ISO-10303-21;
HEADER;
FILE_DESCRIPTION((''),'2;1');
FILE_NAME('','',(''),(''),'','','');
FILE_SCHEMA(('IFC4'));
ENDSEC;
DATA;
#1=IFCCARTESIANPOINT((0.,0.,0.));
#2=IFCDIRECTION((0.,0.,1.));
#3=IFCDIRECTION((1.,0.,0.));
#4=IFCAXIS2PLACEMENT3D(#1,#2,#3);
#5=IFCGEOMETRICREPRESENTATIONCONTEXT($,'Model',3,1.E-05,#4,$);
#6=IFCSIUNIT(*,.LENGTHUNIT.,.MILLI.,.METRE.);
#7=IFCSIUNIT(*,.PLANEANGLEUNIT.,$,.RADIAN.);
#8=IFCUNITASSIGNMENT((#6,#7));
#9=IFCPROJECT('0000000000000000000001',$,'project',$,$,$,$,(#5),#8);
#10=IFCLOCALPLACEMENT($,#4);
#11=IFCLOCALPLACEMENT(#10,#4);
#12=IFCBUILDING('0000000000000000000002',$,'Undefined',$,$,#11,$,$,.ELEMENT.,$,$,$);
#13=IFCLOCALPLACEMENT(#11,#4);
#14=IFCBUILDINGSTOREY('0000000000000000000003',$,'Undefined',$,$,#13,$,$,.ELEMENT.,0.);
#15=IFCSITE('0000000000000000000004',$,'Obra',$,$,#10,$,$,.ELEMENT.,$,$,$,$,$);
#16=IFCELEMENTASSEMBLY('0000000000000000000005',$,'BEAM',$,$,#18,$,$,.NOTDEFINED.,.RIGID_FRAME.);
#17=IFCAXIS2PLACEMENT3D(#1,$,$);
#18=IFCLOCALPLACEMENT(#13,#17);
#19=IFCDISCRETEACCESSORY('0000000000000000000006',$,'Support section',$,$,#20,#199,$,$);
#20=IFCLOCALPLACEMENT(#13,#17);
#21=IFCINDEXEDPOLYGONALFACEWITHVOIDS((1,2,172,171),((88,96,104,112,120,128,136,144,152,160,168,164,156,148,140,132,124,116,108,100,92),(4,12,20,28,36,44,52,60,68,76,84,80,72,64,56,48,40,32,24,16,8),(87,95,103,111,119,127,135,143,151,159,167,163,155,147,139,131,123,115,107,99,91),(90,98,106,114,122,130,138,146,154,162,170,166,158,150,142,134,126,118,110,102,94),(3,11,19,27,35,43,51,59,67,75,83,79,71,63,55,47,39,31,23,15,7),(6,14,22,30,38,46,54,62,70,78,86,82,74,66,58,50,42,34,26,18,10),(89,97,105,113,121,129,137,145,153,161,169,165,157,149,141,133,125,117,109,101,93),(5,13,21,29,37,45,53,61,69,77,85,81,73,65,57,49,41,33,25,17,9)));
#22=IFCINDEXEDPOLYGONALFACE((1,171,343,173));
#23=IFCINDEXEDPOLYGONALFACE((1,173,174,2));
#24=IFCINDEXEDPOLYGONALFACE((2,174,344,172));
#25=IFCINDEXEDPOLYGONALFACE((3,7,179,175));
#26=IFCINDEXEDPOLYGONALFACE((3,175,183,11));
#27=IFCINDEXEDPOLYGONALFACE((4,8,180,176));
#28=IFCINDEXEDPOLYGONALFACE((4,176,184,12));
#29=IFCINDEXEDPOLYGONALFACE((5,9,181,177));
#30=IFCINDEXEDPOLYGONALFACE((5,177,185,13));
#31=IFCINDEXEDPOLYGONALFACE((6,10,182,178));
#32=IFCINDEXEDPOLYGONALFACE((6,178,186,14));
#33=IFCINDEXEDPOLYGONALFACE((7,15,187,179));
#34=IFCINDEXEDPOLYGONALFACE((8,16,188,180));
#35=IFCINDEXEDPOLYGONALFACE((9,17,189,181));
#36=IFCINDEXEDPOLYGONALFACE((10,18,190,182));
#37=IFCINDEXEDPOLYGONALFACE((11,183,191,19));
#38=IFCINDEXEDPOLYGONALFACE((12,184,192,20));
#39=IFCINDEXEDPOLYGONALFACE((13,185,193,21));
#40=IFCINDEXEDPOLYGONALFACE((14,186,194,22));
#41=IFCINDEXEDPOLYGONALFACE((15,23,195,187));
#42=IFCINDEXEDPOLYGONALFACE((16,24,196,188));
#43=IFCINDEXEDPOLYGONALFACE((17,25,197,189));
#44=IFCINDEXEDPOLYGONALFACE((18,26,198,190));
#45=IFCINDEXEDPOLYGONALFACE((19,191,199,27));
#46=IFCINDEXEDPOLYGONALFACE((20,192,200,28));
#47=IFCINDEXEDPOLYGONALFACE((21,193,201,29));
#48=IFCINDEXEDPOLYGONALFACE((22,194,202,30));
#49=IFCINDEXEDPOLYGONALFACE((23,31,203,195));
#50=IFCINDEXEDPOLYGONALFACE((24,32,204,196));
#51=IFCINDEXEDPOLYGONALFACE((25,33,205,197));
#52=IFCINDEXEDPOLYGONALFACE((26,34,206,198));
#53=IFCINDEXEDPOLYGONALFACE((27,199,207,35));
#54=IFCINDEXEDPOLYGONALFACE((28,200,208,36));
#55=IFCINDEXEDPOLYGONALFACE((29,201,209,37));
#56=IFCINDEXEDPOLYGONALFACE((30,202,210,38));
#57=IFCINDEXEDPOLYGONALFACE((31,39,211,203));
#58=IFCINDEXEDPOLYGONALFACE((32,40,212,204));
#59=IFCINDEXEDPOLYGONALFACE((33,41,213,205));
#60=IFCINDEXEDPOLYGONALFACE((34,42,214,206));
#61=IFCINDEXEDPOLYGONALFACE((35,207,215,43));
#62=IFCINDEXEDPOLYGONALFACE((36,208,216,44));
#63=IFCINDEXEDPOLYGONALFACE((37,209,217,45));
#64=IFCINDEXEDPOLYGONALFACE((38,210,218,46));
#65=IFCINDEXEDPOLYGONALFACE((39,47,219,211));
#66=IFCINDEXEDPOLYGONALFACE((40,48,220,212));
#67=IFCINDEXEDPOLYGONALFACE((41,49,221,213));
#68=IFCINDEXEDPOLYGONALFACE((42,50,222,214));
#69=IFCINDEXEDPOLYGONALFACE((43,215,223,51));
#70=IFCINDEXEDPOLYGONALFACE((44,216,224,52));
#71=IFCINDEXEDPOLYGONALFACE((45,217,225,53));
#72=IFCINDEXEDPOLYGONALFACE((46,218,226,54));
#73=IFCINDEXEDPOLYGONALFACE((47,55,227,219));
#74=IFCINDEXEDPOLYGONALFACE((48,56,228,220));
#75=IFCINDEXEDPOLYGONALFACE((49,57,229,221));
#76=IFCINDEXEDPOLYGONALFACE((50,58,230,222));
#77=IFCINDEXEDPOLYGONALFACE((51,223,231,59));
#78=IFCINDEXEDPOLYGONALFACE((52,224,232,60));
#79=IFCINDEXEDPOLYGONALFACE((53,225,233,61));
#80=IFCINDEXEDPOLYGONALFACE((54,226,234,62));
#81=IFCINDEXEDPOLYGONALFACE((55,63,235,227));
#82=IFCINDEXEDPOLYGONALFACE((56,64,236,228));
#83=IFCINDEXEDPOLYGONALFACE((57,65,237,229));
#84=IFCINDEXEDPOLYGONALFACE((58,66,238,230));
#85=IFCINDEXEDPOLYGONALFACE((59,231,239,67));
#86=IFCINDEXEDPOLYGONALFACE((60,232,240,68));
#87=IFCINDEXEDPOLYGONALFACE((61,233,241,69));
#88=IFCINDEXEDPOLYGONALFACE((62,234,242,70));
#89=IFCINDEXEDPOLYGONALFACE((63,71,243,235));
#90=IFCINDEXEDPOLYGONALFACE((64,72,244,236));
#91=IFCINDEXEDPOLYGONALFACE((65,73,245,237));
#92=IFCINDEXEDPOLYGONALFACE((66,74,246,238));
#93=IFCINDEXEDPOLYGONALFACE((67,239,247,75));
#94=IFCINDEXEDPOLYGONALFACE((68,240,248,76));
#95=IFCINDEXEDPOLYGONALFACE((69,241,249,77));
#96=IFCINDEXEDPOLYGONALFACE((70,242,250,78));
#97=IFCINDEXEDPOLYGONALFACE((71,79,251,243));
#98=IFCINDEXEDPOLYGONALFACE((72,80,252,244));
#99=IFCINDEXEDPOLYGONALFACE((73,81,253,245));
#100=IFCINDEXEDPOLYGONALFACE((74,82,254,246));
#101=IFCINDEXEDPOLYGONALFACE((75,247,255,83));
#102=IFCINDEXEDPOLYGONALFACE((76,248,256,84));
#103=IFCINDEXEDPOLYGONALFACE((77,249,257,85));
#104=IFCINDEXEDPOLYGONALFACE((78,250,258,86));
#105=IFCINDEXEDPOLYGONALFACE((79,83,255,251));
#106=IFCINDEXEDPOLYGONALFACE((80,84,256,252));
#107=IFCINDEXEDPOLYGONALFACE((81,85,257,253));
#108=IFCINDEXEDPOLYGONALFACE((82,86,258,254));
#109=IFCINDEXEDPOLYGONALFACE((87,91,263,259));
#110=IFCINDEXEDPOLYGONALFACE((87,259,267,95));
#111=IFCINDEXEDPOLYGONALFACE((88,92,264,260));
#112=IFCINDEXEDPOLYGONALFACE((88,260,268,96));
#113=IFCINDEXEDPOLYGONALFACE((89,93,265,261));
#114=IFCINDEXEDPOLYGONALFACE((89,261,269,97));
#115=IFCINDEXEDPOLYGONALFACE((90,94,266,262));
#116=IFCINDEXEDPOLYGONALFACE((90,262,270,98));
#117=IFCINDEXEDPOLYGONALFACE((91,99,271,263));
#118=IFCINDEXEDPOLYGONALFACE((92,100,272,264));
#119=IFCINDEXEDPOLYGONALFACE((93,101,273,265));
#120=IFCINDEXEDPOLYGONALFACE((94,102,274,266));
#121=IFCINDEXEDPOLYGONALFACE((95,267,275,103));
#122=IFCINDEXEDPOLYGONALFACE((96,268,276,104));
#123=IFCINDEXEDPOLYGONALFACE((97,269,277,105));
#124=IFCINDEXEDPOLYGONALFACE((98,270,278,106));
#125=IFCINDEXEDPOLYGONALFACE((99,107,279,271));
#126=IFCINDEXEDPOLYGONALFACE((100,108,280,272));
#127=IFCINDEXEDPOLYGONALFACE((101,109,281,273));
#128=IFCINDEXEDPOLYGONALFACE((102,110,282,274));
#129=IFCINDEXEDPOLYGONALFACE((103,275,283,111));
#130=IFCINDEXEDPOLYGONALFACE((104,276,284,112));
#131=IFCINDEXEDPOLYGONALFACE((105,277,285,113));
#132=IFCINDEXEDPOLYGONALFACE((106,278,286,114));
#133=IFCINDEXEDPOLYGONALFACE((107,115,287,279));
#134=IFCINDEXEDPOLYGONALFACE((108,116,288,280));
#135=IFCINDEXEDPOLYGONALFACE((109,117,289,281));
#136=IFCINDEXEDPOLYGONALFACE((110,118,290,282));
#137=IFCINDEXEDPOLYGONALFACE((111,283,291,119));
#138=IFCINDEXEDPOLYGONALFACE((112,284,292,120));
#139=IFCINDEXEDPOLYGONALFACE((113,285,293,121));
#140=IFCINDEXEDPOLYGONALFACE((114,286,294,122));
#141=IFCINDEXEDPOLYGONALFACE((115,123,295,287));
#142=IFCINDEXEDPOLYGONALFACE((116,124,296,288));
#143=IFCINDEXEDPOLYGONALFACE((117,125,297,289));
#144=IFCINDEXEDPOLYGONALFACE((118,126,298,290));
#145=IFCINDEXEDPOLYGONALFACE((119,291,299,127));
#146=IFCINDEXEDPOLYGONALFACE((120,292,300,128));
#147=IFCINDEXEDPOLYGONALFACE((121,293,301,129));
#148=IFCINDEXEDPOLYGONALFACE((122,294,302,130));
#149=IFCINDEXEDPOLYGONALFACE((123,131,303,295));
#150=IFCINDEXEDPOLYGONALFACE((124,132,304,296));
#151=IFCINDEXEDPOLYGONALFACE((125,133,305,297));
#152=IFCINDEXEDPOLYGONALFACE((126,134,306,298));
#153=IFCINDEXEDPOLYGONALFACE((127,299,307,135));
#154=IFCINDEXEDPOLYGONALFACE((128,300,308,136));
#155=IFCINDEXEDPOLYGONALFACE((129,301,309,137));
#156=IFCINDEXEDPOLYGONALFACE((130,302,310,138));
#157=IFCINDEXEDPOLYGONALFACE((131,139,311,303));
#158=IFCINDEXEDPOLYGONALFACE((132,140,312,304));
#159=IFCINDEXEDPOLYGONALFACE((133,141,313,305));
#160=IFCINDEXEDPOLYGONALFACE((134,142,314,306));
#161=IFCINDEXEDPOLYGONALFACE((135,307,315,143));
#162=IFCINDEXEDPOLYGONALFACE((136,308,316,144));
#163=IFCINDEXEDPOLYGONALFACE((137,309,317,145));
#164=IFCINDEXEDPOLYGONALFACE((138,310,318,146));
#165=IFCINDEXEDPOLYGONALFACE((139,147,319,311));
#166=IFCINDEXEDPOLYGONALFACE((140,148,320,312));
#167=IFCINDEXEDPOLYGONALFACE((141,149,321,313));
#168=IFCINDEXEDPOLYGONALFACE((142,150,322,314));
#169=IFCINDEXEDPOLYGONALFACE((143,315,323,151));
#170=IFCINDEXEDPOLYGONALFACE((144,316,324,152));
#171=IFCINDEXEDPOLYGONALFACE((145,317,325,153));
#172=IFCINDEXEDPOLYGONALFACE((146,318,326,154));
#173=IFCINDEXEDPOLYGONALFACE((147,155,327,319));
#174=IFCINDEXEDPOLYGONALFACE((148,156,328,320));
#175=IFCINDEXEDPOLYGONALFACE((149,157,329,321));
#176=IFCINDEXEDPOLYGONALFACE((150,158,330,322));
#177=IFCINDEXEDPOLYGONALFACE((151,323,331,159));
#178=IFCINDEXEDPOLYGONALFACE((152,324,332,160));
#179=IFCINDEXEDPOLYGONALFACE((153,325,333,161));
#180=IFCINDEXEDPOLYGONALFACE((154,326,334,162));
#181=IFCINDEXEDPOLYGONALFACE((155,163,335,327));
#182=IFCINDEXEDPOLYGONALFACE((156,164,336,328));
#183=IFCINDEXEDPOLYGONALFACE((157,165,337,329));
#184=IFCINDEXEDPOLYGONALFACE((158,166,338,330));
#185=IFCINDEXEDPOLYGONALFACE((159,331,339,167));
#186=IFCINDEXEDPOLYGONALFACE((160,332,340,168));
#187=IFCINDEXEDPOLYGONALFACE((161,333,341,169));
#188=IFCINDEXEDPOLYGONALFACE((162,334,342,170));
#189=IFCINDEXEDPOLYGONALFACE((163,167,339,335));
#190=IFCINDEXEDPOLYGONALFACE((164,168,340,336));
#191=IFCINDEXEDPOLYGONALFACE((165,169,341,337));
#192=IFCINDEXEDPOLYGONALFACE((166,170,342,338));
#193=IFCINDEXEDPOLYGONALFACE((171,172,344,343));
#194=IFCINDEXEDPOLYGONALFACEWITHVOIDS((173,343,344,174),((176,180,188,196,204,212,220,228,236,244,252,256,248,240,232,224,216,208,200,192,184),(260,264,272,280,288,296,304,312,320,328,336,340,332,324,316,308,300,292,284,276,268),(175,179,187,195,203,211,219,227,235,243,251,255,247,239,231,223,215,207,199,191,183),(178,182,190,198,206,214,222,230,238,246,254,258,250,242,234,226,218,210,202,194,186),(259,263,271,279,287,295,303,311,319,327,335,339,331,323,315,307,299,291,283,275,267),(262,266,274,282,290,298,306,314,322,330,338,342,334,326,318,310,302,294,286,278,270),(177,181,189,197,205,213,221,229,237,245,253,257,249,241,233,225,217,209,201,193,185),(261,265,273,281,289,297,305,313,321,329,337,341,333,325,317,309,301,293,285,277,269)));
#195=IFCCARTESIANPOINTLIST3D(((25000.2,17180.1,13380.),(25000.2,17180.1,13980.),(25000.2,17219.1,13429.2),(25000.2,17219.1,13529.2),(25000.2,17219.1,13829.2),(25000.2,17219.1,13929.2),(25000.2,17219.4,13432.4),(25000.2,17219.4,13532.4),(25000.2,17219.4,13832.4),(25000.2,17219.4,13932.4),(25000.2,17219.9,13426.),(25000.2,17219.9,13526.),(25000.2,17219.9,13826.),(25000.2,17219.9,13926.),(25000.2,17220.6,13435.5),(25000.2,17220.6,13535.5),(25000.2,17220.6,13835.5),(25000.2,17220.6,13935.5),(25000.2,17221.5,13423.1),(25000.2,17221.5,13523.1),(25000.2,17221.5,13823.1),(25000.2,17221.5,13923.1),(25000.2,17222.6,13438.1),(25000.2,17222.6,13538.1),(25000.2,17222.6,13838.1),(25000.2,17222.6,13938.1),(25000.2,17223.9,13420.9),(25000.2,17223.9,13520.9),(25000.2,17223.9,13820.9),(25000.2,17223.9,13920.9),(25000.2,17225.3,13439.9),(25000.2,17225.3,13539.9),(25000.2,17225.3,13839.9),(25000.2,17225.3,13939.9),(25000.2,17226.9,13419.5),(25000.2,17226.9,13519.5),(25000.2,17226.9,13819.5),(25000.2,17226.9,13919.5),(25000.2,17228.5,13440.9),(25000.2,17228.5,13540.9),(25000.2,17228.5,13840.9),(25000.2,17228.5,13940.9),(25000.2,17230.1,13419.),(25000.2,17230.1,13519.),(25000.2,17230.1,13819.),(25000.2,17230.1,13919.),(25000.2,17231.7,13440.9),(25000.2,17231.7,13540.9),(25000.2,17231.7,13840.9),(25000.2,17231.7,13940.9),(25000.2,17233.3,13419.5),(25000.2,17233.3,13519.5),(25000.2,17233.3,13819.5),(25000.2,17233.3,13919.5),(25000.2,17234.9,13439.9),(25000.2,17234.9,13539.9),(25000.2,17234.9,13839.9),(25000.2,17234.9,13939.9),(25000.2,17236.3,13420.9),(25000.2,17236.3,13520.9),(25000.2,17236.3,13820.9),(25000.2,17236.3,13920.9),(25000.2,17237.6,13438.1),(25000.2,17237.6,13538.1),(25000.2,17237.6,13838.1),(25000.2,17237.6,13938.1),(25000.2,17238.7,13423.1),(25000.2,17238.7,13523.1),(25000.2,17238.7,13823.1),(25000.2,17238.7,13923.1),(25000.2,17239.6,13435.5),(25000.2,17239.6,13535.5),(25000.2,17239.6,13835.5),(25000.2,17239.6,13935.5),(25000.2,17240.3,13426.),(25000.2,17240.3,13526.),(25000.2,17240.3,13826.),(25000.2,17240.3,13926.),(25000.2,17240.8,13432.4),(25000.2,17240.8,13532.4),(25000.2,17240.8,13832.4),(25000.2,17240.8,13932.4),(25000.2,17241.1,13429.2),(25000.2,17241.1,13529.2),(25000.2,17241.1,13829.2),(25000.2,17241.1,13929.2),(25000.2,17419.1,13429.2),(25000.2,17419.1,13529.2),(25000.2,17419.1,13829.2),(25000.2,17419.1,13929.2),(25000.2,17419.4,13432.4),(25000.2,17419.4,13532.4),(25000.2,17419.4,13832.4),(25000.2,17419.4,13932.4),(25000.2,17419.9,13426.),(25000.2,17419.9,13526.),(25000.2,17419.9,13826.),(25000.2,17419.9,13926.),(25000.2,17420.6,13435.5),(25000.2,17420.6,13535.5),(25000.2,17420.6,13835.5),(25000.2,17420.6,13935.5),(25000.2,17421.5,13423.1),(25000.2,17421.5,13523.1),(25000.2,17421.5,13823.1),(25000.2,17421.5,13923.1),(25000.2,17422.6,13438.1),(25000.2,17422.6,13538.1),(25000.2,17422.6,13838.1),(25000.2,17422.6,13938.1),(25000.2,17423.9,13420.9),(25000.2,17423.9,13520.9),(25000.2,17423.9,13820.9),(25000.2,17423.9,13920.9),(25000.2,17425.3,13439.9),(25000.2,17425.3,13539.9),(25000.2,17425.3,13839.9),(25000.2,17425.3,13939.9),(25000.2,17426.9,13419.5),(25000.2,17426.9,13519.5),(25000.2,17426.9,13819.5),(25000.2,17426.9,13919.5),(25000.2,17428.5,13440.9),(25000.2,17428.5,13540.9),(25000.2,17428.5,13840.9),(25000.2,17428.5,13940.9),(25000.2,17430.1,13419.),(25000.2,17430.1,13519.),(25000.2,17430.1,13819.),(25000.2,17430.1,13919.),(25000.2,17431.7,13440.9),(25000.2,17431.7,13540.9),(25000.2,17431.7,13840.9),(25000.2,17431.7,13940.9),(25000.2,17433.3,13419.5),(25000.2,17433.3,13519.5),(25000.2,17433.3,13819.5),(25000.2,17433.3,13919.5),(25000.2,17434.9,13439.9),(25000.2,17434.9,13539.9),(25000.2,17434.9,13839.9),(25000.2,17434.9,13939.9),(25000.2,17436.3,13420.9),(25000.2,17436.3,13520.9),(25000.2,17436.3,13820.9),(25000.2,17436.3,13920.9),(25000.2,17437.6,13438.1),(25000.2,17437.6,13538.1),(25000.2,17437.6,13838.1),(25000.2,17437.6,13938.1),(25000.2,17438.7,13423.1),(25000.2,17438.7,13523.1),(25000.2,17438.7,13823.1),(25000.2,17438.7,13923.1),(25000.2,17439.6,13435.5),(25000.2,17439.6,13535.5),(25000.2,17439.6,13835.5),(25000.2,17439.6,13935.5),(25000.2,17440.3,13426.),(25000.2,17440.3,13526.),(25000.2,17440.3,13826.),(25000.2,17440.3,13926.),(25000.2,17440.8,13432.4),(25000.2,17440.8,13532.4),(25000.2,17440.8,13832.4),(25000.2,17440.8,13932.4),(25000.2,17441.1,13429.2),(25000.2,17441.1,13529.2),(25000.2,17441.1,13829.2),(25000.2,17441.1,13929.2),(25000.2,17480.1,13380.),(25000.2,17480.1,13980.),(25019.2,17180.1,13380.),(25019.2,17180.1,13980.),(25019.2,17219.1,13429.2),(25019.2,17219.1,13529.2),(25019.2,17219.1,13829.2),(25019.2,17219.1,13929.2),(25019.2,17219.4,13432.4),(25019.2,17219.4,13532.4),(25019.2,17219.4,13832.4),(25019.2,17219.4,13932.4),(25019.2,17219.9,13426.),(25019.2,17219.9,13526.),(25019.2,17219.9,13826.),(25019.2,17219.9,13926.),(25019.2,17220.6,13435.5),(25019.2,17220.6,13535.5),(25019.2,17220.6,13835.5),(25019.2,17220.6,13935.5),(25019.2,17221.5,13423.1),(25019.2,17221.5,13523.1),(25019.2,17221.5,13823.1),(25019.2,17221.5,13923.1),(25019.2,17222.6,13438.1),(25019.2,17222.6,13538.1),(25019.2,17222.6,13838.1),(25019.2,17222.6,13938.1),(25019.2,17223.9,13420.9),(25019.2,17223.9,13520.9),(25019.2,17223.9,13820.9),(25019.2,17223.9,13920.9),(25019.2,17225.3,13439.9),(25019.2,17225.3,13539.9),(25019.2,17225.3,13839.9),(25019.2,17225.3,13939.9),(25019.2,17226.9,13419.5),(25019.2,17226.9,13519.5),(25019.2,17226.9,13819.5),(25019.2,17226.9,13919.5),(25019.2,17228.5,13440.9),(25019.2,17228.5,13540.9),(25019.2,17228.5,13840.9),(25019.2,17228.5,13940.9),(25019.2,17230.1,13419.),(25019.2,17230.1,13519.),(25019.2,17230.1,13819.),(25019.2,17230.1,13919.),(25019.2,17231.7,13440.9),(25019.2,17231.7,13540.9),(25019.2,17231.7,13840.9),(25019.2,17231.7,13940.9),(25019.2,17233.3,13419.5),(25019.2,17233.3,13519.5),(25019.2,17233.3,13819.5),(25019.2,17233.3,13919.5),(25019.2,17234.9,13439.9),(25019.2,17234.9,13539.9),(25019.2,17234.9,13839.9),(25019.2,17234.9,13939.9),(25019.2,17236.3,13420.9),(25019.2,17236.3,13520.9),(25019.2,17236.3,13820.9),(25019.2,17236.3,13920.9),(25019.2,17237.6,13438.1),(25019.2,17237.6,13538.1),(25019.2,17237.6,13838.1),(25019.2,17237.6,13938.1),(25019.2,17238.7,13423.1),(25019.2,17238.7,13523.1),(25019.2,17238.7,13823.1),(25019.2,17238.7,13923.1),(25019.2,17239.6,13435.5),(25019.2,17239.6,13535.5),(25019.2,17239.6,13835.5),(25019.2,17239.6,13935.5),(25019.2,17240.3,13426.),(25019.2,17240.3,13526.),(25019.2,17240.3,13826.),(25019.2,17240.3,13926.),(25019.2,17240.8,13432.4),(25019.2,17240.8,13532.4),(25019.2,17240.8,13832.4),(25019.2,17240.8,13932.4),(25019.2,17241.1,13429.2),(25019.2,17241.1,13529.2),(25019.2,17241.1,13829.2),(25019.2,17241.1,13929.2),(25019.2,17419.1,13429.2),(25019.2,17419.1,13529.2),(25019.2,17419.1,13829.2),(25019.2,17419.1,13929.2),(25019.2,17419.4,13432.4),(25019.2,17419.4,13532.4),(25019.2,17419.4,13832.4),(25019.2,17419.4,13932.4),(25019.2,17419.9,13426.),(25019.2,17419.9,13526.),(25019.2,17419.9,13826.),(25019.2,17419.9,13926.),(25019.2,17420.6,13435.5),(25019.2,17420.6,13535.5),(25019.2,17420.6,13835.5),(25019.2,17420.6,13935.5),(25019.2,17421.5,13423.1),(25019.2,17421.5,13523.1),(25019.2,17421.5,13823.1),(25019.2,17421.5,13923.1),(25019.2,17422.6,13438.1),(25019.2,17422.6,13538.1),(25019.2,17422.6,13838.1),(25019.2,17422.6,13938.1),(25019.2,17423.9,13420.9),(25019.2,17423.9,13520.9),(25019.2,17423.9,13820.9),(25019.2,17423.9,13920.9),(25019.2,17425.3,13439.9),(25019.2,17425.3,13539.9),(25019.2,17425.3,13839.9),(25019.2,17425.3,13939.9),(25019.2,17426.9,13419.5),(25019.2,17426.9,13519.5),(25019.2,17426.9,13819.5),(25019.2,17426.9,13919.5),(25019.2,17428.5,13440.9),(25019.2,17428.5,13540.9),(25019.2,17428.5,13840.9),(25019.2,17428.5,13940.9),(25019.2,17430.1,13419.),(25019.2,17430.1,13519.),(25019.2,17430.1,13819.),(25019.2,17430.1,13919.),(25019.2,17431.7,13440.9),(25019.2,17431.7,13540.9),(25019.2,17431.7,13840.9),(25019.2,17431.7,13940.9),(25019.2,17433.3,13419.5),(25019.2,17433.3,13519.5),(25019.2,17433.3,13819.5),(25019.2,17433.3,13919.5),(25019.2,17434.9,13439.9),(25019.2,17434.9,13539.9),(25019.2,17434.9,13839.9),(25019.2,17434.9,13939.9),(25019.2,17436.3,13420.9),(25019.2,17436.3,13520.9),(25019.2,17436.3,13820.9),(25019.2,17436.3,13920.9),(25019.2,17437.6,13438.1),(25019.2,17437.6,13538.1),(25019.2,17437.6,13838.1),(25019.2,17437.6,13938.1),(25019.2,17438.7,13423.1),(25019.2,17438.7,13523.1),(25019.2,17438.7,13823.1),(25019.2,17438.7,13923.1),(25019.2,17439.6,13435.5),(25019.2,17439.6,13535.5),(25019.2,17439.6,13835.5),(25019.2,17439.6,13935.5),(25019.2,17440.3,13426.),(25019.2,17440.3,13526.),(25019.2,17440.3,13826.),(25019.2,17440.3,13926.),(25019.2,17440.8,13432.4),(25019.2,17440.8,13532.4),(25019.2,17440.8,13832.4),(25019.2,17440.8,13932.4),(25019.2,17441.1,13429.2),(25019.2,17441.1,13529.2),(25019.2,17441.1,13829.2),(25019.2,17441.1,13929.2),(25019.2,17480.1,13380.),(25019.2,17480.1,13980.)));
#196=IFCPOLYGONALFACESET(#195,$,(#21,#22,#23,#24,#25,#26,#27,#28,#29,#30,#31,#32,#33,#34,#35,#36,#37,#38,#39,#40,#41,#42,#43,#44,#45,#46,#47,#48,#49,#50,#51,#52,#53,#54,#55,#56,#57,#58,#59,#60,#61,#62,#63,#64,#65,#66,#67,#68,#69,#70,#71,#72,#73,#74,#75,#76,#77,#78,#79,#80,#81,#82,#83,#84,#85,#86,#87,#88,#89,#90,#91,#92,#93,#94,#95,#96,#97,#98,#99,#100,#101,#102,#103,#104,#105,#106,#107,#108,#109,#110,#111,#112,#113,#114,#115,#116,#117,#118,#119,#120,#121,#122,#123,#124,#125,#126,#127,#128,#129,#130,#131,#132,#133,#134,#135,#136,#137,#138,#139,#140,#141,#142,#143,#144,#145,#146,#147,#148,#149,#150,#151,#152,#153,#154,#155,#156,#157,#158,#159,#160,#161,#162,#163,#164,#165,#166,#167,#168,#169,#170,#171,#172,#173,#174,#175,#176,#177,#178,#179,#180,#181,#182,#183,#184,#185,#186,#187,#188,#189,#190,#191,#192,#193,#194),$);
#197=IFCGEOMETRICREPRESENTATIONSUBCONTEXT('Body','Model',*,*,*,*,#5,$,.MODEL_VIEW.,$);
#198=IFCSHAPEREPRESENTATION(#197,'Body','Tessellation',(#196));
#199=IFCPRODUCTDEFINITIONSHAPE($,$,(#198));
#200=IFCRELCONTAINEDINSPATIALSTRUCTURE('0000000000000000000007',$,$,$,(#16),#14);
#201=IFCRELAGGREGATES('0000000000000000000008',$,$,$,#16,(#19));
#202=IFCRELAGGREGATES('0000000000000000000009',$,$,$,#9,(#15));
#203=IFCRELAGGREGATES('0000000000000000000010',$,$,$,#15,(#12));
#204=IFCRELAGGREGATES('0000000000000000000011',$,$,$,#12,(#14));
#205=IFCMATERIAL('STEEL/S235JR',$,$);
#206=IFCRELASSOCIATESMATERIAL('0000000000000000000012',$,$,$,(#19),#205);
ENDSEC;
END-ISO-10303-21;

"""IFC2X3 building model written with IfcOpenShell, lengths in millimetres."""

from ifc_helpers import new_model, si_unit, frame, origin_with_axes, origin_2d_with_axis, place, context, subcontext, project, spatial, rectangle, circle, extrude, source, transform, mapped, material, element, aggregate, save


model = new_model("IFC2X3")

# Units and contexts
model_context = context("Model", 3, precision=1e-05, world=origin_with_axes())
body_context = subcontext(model_context, "Body", "Model", "MODEL_VIEW")
ifc_project = project(units=[si_unit("LENGTHUNIT", "METRE", prefix="MILLI"), si_unit("PLANEANGLEUNIT", "RADIAN")], contexts=[model_context])

# Site, building, storey
site_placement = place(None, origin_with_axes())
site = spatial("IfcSite", under=ifc_project, at=site_placement, Name="Obra", CompositionType="ELEMENT")
building_placement = place(site_placement, origin_with_axes())
building = spatial("IfcBuilding", under=site, at=building_placement, Name="Undefined", CompositionType="ELEMENT")
storey_placement = place(building_placement, origin_with_axes())
storey = spatial("IfcBuildingStorey", under=building, at=storey_placement, Name="Undefined", CompositionType="ELEMENT", Elevation=0.0)

# Shared definitions
ifc_material_1 = material(Name="STEEL/S235JR")

# Element assembly
assembly_1_placement = place(storey_placement, origin_with_axes())
assembly_1 = element("IfcElementAssembly", 1, at=assembly_1_placement, inside=storey, Name="BEAM", AssemblyPlace="NOTDEFINED", PredefinedType="RIGID_FRAME")

# Discrete accessory, opening
discrete_accessory_1_placement = place(assembly_1_placement, frame((25009.7, 17330.1, 13380.0), z_axis=(0.0, 0.0, 1.0), x_axis=(-0.000129, -1.0, 0.0)))
discrete_accessory_1 = element("IfcDiscreteAccessory", 2, at=discrete_accessory_1_placement, material=ifc_material_1, Name="Support section", context=body_context, shape_type="SweptSolid", body=[
    extrude(rectangle(XDim=19.0, YDim=300.0, at=origin_2d_with_axis()), frame((0.0, 0.0, 600.0), z_axis=(0.0, 0.0, -1.0), x_axis=(0.0, 1.0, 0.0)), (0.0, 0.0, 1.0), 600.0),
])
shared_shape_1 = source(origin_with_axes(), body_context, "Body", "SweptSolid", [
    extrude(circle(Radius=11.0, at=origin_2d_with_axis()), frame((0.0, -0.1, 0.0), z_axis=(0.0, 1.0, 0.0), x_axis=(1.0, 0.0, 0.0)), (0.0, 0.0, 1.0), 19.2),
])
opening_1_placement = place(assembly_1_placement, frame((25000.2, 17330.1, 13900.0), z_axis=(-0.000129, -1.0, 0.0), x_axis=(0.0, 0.0, -1.0)))
element("IfcOpeningElement", 3, at=opening_1_placement, cuts=discrete_accessory_1, ObjectType="Opening", context=body_context, shape_type="MappedRepresentation", body=[
    mapped(shared_shape_1, transform((-30.0, 0.0, -100.0))),
    mapped(shared_shape_1, transform((-30.0, 0.0, 100.0))),
    mapped(shared_shape_1, transform((70.0, 0.0, -100.0))),
    mapped(shared_shape_1, transform((70.0, 0.0, 100.0))),
    mapped(shared_shape_1, transform((370.0, 0.0, -100.0))),
    mapped(shared_shape_1, transform((370.0, 0.0, 100.0))),
    mapped(shared_shape_1, transform((470.0, 0.0, -100.0))),
    mapped(shared_shape_1, transform((470.0, 0.0, 100.0))),
])
aggregate(assembly_1, [discrete_accessory_1])

save(model, "model.ifc")
